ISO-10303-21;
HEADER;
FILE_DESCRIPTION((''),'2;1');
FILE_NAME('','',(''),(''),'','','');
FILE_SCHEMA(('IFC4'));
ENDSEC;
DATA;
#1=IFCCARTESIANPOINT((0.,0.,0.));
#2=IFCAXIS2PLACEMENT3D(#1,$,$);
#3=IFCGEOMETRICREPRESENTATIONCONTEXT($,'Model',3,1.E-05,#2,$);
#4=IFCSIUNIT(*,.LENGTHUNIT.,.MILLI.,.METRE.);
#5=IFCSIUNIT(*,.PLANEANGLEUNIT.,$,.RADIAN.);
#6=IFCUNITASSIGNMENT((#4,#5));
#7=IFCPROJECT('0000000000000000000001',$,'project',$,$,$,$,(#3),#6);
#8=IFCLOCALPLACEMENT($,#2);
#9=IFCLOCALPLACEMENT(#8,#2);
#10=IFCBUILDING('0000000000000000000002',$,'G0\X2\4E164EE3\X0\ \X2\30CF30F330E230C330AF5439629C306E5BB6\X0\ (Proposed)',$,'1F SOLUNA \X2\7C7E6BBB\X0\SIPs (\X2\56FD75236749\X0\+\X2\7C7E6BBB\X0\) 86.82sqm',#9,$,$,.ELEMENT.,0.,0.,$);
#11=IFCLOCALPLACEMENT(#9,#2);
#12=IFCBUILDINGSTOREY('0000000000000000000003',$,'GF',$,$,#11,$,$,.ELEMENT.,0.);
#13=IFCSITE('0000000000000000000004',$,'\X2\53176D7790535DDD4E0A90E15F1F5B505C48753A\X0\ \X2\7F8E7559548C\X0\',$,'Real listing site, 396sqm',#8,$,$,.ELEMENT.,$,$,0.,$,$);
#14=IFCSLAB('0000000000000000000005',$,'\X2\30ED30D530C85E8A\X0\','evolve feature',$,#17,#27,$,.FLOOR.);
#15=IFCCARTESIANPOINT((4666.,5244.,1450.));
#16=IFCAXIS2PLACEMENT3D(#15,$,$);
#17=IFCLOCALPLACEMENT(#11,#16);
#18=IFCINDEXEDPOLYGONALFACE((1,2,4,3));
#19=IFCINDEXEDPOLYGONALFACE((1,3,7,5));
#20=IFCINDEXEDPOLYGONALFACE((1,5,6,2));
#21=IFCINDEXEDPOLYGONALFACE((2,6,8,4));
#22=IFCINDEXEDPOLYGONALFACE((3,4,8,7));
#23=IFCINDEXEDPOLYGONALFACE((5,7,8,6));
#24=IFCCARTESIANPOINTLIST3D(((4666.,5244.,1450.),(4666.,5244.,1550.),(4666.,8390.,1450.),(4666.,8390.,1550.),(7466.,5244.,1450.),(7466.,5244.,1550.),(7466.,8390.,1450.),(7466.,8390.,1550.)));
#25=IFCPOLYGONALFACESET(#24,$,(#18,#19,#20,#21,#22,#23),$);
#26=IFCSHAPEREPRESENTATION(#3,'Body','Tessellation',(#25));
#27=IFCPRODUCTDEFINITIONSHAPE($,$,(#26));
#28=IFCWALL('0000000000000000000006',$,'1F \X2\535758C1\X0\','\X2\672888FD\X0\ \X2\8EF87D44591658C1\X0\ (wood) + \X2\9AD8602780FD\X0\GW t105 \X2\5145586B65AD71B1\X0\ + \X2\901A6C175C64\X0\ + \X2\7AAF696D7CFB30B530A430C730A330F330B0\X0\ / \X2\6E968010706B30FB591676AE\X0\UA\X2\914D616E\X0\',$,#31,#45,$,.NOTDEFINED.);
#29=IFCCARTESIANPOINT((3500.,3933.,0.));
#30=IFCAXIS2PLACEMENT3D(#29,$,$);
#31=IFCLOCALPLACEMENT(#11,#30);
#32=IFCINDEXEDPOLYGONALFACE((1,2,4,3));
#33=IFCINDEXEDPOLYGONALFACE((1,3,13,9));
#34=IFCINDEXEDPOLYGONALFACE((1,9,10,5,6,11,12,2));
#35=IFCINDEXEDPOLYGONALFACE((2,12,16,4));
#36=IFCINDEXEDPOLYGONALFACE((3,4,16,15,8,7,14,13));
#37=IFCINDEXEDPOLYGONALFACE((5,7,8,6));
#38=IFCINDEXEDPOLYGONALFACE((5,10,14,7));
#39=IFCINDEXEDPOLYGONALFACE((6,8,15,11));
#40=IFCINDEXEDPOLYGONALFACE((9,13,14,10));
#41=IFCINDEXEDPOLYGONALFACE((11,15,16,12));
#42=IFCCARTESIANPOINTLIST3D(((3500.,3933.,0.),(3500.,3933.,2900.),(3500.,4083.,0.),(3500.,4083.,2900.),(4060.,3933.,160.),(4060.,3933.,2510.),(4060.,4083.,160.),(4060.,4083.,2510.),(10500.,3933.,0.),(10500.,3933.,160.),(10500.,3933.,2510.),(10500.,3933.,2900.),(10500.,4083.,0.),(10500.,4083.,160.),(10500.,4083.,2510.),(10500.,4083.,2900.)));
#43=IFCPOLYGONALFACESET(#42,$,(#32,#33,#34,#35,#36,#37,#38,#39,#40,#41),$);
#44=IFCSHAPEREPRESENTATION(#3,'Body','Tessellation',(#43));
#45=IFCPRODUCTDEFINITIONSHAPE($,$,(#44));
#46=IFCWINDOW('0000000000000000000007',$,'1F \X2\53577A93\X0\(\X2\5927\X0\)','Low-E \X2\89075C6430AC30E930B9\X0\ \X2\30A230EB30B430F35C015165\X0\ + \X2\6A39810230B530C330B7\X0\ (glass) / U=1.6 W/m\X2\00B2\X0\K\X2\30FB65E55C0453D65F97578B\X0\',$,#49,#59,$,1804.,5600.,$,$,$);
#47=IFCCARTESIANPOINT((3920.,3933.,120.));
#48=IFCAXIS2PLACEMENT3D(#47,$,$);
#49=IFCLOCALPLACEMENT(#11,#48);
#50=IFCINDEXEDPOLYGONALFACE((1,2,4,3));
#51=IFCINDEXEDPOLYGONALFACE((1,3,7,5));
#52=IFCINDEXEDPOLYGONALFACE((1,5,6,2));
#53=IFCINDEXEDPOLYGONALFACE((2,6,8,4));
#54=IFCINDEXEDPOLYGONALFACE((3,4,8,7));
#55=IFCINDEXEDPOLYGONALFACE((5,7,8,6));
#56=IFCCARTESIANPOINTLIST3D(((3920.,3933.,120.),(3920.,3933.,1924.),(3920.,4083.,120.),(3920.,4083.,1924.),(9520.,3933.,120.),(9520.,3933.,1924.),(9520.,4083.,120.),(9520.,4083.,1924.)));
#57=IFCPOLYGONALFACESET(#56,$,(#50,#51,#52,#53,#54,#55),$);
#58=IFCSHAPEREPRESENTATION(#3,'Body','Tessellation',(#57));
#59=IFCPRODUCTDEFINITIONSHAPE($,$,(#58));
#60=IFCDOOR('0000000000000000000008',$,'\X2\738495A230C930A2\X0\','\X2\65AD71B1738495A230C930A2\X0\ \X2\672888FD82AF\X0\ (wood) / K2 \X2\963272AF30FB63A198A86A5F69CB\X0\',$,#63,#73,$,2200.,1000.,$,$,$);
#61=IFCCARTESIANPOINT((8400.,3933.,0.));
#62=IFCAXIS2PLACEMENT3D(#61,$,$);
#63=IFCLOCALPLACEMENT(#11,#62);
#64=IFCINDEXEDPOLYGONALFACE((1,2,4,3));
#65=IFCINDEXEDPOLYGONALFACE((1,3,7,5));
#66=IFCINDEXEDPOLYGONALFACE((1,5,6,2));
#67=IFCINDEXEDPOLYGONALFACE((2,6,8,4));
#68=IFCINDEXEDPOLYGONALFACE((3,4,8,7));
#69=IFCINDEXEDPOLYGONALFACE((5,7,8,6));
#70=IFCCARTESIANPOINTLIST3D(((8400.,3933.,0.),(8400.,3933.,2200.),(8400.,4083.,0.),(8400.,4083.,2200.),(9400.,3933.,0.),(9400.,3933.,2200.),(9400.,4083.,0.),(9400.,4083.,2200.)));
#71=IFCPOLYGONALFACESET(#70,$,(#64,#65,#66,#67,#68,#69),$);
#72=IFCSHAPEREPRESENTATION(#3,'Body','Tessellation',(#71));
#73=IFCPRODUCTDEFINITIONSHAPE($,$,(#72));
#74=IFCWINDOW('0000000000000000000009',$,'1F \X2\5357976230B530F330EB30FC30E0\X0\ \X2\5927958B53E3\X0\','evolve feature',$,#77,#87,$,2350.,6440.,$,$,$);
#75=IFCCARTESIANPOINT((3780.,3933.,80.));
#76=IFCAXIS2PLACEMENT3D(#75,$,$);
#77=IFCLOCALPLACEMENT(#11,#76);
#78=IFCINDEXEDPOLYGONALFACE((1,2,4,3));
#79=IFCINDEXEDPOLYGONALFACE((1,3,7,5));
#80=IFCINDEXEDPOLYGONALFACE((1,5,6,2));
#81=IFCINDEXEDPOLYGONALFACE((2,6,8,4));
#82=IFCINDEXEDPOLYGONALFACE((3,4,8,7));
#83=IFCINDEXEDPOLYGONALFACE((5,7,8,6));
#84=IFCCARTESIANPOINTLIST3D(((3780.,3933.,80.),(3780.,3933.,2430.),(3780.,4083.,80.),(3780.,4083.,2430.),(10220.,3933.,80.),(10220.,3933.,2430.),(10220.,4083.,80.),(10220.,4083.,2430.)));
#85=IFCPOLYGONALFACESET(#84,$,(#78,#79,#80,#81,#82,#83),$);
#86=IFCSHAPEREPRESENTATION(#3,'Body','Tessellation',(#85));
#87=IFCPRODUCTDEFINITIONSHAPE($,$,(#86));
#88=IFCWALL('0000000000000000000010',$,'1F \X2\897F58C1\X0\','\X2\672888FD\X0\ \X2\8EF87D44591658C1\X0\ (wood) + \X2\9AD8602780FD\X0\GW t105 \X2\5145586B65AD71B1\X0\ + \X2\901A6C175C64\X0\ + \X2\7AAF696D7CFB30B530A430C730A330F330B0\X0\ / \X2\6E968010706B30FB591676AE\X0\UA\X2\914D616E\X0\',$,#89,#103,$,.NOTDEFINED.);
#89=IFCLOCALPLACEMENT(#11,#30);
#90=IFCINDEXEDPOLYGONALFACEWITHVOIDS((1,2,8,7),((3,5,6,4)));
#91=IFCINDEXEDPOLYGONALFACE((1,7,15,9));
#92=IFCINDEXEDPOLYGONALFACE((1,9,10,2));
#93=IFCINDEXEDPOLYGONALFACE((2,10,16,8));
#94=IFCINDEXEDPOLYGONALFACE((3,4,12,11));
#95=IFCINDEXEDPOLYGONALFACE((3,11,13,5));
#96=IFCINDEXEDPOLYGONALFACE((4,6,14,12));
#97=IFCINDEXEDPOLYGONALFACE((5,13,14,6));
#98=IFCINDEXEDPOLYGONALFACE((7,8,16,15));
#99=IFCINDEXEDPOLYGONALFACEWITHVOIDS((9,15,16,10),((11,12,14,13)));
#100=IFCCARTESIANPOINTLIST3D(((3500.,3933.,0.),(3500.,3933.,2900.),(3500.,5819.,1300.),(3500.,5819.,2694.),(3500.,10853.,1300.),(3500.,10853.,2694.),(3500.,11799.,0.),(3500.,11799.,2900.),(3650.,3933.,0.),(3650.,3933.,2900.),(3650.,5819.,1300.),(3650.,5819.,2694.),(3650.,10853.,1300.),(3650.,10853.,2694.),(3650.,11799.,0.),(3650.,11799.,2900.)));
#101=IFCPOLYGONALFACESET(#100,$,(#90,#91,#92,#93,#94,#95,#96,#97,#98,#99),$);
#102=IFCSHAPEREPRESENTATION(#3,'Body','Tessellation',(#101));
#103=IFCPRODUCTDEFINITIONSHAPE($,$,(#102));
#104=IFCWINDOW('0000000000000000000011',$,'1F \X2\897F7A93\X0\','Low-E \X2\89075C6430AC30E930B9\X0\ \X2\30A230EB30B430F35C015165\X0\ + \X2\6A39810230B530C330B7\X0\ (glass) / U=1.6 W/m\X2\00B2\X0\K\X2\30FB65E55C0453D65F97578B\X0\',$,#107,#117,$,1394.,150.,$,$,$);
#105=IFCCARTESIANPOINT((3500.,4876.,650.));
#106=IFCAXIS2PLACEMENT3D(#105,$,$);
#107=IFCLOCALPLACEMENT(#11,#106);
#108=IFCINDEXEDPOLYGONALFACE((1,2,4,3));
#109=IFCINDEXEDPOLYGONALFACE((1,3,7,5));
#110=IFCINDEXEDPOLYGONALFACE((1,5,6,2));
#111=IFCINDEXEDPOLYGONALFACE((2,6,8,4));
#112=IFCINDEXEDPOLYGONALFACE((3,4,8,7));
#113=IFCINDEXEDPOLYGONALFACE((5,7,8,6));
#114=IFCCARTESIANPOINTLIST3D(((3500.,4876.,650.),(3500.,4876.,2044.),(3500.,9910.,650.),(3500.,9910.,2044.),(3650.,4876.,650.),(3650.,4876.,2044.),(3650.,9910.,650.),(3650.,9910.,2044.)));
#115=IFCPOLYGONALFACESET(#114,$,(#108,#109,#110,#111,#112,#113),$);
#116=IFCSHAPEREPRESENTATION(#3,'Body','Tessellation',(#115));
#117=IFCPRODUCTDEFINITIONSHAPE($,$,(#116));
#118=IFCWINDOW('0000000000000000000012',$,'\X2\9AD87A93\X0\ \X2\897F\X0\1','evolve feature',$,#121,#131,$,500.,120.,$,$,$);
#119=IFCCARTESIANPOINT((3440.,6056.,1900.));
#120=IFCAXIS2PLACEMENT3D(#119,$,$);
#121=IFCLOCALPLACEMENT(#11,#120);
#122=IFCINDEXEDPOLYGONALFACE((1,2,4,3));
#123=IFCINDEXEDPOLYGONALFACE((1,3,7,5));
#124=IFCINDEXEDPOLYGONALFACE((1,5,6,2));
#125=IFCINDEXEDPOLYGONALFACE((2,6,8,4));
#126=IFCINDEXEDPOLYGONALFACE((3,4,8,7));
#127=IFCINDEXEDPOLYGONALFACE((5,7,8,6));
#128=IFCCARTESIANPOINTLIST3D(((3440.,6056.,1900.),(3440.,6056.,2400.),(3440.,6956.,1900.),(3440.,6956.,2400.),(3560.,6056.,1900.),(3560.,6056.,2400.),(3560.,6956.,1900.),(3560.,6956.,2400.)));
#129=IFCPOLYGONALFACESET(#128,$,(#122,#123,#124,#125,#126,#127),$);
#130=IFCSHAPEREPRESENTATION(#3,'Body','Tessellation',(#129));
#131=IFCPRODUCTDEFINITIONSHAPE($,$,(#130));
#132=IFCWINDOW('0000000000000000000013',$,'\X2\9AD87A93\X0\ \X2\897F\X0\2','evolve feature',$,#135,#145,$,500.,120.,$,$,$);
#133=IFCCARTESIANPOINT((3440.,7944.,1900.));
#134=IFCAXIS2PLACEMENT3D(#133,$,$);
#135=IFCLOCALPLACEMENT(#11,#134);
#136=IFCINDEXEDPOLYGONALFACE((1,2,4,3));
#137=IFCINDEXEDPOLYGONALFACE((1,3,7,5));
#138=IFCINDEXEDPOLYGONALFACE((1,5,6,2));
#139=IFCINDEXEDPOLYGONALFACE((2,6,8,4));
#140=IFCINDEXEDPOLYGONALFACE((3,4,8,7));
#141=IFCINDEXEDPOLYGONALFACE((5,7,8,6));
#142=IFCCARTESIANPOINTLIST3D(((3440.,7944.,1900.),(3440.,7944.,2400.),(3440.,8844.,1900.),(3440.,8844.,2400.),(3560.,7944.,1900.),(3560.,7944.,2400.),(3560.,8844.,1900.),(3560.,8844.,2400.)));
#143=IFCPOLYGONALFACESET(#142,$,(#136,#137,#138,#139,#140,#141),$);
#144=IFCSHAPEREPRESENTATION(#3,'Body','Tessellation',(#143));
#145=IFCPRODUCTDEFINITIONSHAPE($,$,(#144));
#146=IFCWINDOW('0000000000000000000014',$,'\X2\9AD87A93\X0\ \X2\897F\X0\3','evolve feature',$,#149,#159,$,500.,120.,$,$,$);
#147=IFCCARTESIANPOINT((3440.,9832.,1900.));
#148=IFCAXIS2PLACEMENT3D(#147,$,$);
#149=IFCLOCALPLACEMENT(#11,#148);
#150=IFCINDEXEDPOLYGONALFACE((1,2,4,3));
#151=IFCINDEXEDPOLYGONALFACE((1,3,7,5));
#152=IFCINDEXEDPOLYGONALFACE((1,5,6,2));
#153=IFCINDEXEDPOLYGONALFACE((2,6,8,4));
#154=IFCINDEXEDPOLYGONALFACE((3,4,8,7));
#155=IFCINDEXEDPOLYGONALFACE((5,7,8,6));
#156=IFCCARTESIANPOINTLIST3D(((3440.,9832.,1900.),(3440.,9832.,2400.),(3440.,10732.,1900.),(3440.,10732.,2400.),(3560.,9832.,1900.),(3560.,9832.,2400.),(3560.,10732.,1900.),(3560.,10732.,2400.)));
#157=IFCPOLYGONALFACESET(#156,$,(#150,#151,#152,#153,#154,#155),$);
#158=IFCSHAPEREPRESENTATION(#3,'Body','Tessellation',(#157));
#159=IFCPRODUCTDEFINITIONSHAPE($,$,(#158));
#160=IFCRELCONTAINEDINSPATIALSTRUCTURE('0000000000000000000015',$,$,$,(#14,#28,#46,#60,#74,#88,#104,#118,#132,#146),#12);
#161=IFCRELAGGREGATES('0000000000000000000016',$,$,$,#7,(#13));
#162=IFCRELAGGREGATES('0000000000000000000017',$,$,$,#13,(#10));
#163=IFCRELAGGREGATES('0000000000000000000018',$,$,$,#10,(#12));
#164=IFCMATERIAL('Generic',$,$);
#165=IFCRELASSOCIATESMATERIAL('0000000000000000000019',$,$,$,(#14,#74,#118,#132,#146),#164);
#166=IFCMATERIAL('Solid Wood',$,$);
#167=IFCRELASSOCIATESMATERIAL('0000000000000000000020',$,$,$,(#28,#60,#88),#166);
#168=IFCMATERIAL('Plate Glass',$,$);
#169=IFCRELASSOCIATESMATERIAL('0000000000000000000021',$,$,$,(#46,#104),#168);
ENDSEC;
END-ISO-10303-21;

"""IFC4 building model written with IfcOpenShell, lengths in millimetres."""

from ifc_helpers import new_model, si_unit, frame, frame_2d, origin, place, context, project, spatial, rectangle, extrude, material, element, fill, save


model = new_model("IFC4")

# Units and contexts
model_context = context("Model", 3, precision=1e-05, world=origin())
ifc_project = project(units=[si_unit("LENGTHUNIT", "METRE", prefix="MILLI"), si_unit("PLANEANGLEUNIT", "RADIAN")], contexts=[model_context])

# Site, building, storey
site_placement = place(None, origin())
site = spatial("IfcSite", under=ifc_project, at=site_placement, Name="北海道川上郡弟子屈町 美留和", ObjectType="Real listing site, 396sqm", CompositionType="ELEMENT", RefElevation=0.0)
building_placement = place(site_placement, origin())
building = spatial("IfcBuilding", under=site, at=building_placement, Name="G0世代 ハンモック吹抜の家 (Proposed)", ObjectType="1F SOLUNA 籾殻SIPs (国産杉+籾殻) 86.82sqm", CompositionType="ELEMENT", ElevationOfRefHeight=0.0, ElevationOfTerrain=0.0)
storey_placement = place(building_placement, origin())
storey = spatial("IfcBuildingStorey", under=building, at=storey_placement, Name="GF", CompositionType="ELEMENT", Elevation=0.0)

# Slab
ifc_material_1 = material(Name="Solid Wood")
ifc_material_2 = material(Name="Generic")
slab_1_placement = place(storey_placement, frame((4666.0, 5244.0, 1450.0)))
element("IfcSlab", 1, at=slab_1_placement, inside=storey, material=ifc_material_2, Name="ロフト床", Description="evolve feature", PredefinedType="FLOOR", context=model_context, shape_type="SweptSolid", body=[
    extrude(rectangle(XDim=2800.0, YDim=3146.0, at=frame_2d((1400.0, 1573.0))), frame((4666.0, 5244.0, 1450.0)), (0.0, 0.0, 1.0), 100.0),
])

# Wall, openings, windows, door
wall_1_placement = place(storey_placement, frame((3500.0, 3933.0, 0.0)))
wall_1 = element("IfcWall", 2, at=wall_1_placement, inside=storey, material=ifc_material_1, Name="1F 南壁", Description="木製 軸組外壁 (wood) + 高性能GW t105 充填断熱 + 通気層 + 窯業系サイディング / 準耐火・外皮UA配慮", PredefinedType="NOTDEFINED", context=model_context, shape_type="SweptSolid", body=[
    extrude(rectangle(XDim=7000.0, YDim=150.0, at=frame_2d((3500.0, 75.0))), frame((3500.0, 3933.0, 0.0)), (0.0, 0.0, 1.0), 2900.0),
])
opening_1_placement = place(storey_placement, frame((3920.0, 3933.0, 120.0)))
opening_1 = element("IfcOpeningElement", 3, at=opening_1_placement, cuts=wall_1, PredefinedType="NOTDEFINED", context=model_context, shape_type="SweptSolid", body=[
    extrude(rectangle(XDim=5600.0, YDim=150.0, at=frame_2d((2800.0, 75.0))), frame((3920.0, 3933.0, 120.0)), (0.0, 0.0, 1.0), 1804.0),
])
opening_2_placement = place(storey_placement, frame((8400.0, 3933.0, 0.0)))
opening_2 = element("IfcOpeningElement", 4, at=opening_2_placement, cuts=wall_1, PredefinedType="NOTDEFINED", context=model_context, shape_type="SweptSolid", body=[
    extrude(rectangle(XDim=1000.0, YDim=150.0, at=frame_2d((500.0, 75.0))), frame((8400.0, 3933.0, 0.0)), (0.0, 0.0, 1.0), 2200.0),
])
opening_3_placement = place(storey_placement, frame((3780.0, 3933.0, 80.0)))
opening_3 = element("IfcOpeningElement", 5, at=opening_3_placement, cuts=wall_1, PredefinedType="NOTDEFINED", context=model_context, shape_type="SweptSolid", body=[
    extrude(rectangle(XDim=6440.0, YDim=150.0, at=frame_2d((3220.0, 75.0))), frame((3780.0, 3933.0, 80.0)), (0.0, 0.0, 1.0), 2350.0),
])
ifc_material_3 = material(Name="Plate Glass")
window_1_placement = place(storey_placement, frame((3920.0, 3933.0, 120.0)))
window_1 = element("IfcWindow", 6, at=window_1_placement, inside=storey, material=ifc_material_3, Name="1F 南窓(大)", Description="Low-E 複層ガラス アルゴン封入 + 樹脂サッシ (glass) / U=1.6 W/m²K・日射取得型", OverallHeight=1804.0, OverallWidth=5600.0, context=model_context, shape_type="SweptSolid", body=[
    extrude(rectangle(XDim=5600.0, YDim=150.0, at=frame_2d((2800.0, 75.0))), frame((3920.0, 3933.0, 120.0)), (0.0, 0.0, 1.0), 1804.0),
])
fill(opening_1, window_1)
door_placement = place(storey_placement, frame((8400.0, 3933.0, 0.0)))
door = element("IfcDoor", 7, at=door_placement, inside=storey, material=ifc_material_1, Name="玄関ドア", Description="断熱玄関ドア 木製芯 (wood) / K2 防犯・採風機構", OverallHeight=2200.0, OverallWidth=1000.0, context=model_context, shape_type="SweptSolid", body=[
    extrude(rectangle(XDim=1000.0, YDim=150.0, at=frame_2d((500.0, 75.0))), frame((8400.0, 3933.0, 0.0)), (0.0, 0.0, 1.0), 2200.0),
])
fill(opening_2, door)
window_2_placement = place(storey_placement, frame((3780.0, 3933.0, 80.0)))
window_2 = element("IfcWindow", 8, at=window_2_placement, inside=storey, material=ifc_material_2, Name="1F 南面サンルーム 大開口", Description="evolve feature", OverallHeight=2350.0, OverallWidth=6440.0, context=model_context, shape_type="SweptSolid", body=[
    extrude(rectangle(XDim=6440.0, YDim=150.0, at=frame_2d((3220.0, 75.0))), frame((3780.0, 3933.0, 80.0)), (0.0, 0.0, 1.0), 2350.0),
])
fill(opening_3, window_2)

# Wall, openings, windows
wall_2_placement = place(storey_placement, frame((3500.0, 3933.0, 0.0)))
wall_2 = element("IfcWall", 9, at=wall_2_placement, inside=storey, material=ifc_material_1, Name="1F 西壁", Description="木製 軸組外壁 (wood) + 高性能GW t105 充填断熱 + 通気層 + 窯業系サイディング / 準耐火・外皮UA配慮", PredefinedType="NOTDEFINED", context=model_context, shape_type="SweptSolid", body=[
    extrude(rectangle(XDim=150.0, YDim=7866.0, at=frame_2d((75.0, 3933.0))), frame((3500.0, 3933.0, 0.0)), (0.0, 0.0, 1.0), 2900.0),
])
opening_4_placement = place(storey_placement, frame((3500.0, 4876.0, 650.0)))
opening_4 = element("IfcOpeningElement", 10, at=opening_4_placement, cuts=wall_2, PredefinedType="NOTDEFINED", context=model_context, shape_type="SweptSolid", body=[
    extrude(rectangle(XDim=150.0, YDim=5034.0, at=frame_2d((75.0, 2517.0))), frame((3500.0, 4876.0, 650.0)), (0.0, 0.0, 1.0), 1394.0),
])
opening_5_placement = place(storey_placement, frame((3440.0, 6056.0, 1900.0)))
opening_5 = element("IfcOpeningElement", 11, at=opening_5_placement, cuts=wall_2, PredefinedType="NOTDEFINED", context=model_context, shape_type="SweptSolid", body=[
    extrude(rectangle(XDim=120.0, YDim=900.0, at=frame_2d((60.0, 450.0))), frame((3440.0, 6056.0, 1900.0)), (0.0, 0.0, 1.0), 500.0),
])
opening_6_placement = place(storey_placement, frame((3440.0, 7944.0, 1900.0)))
opening_6 = element("IfcOpeningElement", 12, at=opening_6_placement, cuts=wall_2, PredefinedType="NOTDEFINED", context=model_context, shape_type="SweptSolid", body=[
    extrude(rectangle(XDim=120.0, YDim=900.0, at=frame_2d((60.0, 450.0))), frame((3440.0, 7944.0, 1900.0)), (0.0, 0.0, 1.0), 500.0),
])
opening_7_placement = place(storey_placement, frame((3440.0, 9832.0, 1900.0)))
opening_7 = element("IfcOpeningElement", 13, at=opening_7_placement, cuts=wall_2, PredefinedType="NOTDEFINED", context=model_context, shape_type="SweptSolid", body=[
    extrude(rectangle(XDim=120.0, YDim=900.0, at=frame_2d((60.0, 450.0))), frame((3440.0, 9832.0, 1900.0)), (0.0, 0.0, 1.0), 500.0),
])
window_3_placement = place(storey_placement, frame((3500.0, 4876.0, 650.0)))
window_3 = element("IfcWindow", 14, at=window_3_placement, inside=storey, material=ifc_material_3, Name="1F 西窓", Description="Low-E 複層ガラス アルゴン封入 + 樹脂サッシ (glass) / U=1.6 W/m²K・日射取得型", OverallHeight=1394.0, OverallWidth=150.0, context=model_context, shape_type="SweptSolid", body=[
    extrude(rectangle(XDim=150.0, YDim=5034.0, at=frame_2d((75.0, 2517.0))), frame((3500.0, 4876.0, 650.0)), (0.0, 0.0, 1.0), 1394.0),
])
fill(opening_4, window_3)
window_4_placement = place(storey_placement, frame((3440.0, 6056.0, 1900.0)))
window_4 = element("IfcWindow", 15, at=window_4_placement, inside=storey, material=ifc_material_2, Name="高窓 西1", Description="evolve feature", OverallHeight=500.0, OverallWidth=120.0, context=model_context, shape_type="SweptSolid", body=[
    extrude(rectangle(XDim=120.0, YDim=900.0, at=frame_2d((60.0, 450.0))), frame((3440.0, 6056.0, 1900.0)), (0.0, 0.0, 1.0), 500.0),
])
fill(opening_5, window_4)
window_5_placement = place(storey_placement, frame((3440.0, 7944.0, 1900.0)))
window_5 = element("IfcWindow", 16, at=window_5_placement, inside=storey, material=ifc_material_2, Name="高窓 西2", Description="evolve feature", OverallHeight=500.0, OverallWidth=120.0, context=model_context, shape_type="SweptSolid", body=[
    extrude(rectangle(XDim=120.0, YDim=900.0, at=frame_2d((60.0, 450.0))), frame((3440.0, 7944.0, 1900.0)), (0.0, 0.0, 1.0), 500.0),
])
fill(opening_6, window_5)
window_6_placement = place(storey_placement, frame((3440.0, 9832.0, 1900.0)))
window_6 = element("IfcWindow", 17, at=window_6_placement, inside=storey, material=ifc_material_2, Name="高窓 西3", Description="evolve feature", OverallHeight=500.0, OverallWidth=120.0, context=model_context, shape_type="SweptSolid", body=[
    extrude(rectangle(XDim=120.0, YDim=900.0, at=frame_2d((60.0, 450.0))), frame((3440.0, 9832.0, 1900.0)), (0.0, 0.0, 1.0), 500.0),
])
fill(opening_7, window_6)

save(model, "model.ifc")
